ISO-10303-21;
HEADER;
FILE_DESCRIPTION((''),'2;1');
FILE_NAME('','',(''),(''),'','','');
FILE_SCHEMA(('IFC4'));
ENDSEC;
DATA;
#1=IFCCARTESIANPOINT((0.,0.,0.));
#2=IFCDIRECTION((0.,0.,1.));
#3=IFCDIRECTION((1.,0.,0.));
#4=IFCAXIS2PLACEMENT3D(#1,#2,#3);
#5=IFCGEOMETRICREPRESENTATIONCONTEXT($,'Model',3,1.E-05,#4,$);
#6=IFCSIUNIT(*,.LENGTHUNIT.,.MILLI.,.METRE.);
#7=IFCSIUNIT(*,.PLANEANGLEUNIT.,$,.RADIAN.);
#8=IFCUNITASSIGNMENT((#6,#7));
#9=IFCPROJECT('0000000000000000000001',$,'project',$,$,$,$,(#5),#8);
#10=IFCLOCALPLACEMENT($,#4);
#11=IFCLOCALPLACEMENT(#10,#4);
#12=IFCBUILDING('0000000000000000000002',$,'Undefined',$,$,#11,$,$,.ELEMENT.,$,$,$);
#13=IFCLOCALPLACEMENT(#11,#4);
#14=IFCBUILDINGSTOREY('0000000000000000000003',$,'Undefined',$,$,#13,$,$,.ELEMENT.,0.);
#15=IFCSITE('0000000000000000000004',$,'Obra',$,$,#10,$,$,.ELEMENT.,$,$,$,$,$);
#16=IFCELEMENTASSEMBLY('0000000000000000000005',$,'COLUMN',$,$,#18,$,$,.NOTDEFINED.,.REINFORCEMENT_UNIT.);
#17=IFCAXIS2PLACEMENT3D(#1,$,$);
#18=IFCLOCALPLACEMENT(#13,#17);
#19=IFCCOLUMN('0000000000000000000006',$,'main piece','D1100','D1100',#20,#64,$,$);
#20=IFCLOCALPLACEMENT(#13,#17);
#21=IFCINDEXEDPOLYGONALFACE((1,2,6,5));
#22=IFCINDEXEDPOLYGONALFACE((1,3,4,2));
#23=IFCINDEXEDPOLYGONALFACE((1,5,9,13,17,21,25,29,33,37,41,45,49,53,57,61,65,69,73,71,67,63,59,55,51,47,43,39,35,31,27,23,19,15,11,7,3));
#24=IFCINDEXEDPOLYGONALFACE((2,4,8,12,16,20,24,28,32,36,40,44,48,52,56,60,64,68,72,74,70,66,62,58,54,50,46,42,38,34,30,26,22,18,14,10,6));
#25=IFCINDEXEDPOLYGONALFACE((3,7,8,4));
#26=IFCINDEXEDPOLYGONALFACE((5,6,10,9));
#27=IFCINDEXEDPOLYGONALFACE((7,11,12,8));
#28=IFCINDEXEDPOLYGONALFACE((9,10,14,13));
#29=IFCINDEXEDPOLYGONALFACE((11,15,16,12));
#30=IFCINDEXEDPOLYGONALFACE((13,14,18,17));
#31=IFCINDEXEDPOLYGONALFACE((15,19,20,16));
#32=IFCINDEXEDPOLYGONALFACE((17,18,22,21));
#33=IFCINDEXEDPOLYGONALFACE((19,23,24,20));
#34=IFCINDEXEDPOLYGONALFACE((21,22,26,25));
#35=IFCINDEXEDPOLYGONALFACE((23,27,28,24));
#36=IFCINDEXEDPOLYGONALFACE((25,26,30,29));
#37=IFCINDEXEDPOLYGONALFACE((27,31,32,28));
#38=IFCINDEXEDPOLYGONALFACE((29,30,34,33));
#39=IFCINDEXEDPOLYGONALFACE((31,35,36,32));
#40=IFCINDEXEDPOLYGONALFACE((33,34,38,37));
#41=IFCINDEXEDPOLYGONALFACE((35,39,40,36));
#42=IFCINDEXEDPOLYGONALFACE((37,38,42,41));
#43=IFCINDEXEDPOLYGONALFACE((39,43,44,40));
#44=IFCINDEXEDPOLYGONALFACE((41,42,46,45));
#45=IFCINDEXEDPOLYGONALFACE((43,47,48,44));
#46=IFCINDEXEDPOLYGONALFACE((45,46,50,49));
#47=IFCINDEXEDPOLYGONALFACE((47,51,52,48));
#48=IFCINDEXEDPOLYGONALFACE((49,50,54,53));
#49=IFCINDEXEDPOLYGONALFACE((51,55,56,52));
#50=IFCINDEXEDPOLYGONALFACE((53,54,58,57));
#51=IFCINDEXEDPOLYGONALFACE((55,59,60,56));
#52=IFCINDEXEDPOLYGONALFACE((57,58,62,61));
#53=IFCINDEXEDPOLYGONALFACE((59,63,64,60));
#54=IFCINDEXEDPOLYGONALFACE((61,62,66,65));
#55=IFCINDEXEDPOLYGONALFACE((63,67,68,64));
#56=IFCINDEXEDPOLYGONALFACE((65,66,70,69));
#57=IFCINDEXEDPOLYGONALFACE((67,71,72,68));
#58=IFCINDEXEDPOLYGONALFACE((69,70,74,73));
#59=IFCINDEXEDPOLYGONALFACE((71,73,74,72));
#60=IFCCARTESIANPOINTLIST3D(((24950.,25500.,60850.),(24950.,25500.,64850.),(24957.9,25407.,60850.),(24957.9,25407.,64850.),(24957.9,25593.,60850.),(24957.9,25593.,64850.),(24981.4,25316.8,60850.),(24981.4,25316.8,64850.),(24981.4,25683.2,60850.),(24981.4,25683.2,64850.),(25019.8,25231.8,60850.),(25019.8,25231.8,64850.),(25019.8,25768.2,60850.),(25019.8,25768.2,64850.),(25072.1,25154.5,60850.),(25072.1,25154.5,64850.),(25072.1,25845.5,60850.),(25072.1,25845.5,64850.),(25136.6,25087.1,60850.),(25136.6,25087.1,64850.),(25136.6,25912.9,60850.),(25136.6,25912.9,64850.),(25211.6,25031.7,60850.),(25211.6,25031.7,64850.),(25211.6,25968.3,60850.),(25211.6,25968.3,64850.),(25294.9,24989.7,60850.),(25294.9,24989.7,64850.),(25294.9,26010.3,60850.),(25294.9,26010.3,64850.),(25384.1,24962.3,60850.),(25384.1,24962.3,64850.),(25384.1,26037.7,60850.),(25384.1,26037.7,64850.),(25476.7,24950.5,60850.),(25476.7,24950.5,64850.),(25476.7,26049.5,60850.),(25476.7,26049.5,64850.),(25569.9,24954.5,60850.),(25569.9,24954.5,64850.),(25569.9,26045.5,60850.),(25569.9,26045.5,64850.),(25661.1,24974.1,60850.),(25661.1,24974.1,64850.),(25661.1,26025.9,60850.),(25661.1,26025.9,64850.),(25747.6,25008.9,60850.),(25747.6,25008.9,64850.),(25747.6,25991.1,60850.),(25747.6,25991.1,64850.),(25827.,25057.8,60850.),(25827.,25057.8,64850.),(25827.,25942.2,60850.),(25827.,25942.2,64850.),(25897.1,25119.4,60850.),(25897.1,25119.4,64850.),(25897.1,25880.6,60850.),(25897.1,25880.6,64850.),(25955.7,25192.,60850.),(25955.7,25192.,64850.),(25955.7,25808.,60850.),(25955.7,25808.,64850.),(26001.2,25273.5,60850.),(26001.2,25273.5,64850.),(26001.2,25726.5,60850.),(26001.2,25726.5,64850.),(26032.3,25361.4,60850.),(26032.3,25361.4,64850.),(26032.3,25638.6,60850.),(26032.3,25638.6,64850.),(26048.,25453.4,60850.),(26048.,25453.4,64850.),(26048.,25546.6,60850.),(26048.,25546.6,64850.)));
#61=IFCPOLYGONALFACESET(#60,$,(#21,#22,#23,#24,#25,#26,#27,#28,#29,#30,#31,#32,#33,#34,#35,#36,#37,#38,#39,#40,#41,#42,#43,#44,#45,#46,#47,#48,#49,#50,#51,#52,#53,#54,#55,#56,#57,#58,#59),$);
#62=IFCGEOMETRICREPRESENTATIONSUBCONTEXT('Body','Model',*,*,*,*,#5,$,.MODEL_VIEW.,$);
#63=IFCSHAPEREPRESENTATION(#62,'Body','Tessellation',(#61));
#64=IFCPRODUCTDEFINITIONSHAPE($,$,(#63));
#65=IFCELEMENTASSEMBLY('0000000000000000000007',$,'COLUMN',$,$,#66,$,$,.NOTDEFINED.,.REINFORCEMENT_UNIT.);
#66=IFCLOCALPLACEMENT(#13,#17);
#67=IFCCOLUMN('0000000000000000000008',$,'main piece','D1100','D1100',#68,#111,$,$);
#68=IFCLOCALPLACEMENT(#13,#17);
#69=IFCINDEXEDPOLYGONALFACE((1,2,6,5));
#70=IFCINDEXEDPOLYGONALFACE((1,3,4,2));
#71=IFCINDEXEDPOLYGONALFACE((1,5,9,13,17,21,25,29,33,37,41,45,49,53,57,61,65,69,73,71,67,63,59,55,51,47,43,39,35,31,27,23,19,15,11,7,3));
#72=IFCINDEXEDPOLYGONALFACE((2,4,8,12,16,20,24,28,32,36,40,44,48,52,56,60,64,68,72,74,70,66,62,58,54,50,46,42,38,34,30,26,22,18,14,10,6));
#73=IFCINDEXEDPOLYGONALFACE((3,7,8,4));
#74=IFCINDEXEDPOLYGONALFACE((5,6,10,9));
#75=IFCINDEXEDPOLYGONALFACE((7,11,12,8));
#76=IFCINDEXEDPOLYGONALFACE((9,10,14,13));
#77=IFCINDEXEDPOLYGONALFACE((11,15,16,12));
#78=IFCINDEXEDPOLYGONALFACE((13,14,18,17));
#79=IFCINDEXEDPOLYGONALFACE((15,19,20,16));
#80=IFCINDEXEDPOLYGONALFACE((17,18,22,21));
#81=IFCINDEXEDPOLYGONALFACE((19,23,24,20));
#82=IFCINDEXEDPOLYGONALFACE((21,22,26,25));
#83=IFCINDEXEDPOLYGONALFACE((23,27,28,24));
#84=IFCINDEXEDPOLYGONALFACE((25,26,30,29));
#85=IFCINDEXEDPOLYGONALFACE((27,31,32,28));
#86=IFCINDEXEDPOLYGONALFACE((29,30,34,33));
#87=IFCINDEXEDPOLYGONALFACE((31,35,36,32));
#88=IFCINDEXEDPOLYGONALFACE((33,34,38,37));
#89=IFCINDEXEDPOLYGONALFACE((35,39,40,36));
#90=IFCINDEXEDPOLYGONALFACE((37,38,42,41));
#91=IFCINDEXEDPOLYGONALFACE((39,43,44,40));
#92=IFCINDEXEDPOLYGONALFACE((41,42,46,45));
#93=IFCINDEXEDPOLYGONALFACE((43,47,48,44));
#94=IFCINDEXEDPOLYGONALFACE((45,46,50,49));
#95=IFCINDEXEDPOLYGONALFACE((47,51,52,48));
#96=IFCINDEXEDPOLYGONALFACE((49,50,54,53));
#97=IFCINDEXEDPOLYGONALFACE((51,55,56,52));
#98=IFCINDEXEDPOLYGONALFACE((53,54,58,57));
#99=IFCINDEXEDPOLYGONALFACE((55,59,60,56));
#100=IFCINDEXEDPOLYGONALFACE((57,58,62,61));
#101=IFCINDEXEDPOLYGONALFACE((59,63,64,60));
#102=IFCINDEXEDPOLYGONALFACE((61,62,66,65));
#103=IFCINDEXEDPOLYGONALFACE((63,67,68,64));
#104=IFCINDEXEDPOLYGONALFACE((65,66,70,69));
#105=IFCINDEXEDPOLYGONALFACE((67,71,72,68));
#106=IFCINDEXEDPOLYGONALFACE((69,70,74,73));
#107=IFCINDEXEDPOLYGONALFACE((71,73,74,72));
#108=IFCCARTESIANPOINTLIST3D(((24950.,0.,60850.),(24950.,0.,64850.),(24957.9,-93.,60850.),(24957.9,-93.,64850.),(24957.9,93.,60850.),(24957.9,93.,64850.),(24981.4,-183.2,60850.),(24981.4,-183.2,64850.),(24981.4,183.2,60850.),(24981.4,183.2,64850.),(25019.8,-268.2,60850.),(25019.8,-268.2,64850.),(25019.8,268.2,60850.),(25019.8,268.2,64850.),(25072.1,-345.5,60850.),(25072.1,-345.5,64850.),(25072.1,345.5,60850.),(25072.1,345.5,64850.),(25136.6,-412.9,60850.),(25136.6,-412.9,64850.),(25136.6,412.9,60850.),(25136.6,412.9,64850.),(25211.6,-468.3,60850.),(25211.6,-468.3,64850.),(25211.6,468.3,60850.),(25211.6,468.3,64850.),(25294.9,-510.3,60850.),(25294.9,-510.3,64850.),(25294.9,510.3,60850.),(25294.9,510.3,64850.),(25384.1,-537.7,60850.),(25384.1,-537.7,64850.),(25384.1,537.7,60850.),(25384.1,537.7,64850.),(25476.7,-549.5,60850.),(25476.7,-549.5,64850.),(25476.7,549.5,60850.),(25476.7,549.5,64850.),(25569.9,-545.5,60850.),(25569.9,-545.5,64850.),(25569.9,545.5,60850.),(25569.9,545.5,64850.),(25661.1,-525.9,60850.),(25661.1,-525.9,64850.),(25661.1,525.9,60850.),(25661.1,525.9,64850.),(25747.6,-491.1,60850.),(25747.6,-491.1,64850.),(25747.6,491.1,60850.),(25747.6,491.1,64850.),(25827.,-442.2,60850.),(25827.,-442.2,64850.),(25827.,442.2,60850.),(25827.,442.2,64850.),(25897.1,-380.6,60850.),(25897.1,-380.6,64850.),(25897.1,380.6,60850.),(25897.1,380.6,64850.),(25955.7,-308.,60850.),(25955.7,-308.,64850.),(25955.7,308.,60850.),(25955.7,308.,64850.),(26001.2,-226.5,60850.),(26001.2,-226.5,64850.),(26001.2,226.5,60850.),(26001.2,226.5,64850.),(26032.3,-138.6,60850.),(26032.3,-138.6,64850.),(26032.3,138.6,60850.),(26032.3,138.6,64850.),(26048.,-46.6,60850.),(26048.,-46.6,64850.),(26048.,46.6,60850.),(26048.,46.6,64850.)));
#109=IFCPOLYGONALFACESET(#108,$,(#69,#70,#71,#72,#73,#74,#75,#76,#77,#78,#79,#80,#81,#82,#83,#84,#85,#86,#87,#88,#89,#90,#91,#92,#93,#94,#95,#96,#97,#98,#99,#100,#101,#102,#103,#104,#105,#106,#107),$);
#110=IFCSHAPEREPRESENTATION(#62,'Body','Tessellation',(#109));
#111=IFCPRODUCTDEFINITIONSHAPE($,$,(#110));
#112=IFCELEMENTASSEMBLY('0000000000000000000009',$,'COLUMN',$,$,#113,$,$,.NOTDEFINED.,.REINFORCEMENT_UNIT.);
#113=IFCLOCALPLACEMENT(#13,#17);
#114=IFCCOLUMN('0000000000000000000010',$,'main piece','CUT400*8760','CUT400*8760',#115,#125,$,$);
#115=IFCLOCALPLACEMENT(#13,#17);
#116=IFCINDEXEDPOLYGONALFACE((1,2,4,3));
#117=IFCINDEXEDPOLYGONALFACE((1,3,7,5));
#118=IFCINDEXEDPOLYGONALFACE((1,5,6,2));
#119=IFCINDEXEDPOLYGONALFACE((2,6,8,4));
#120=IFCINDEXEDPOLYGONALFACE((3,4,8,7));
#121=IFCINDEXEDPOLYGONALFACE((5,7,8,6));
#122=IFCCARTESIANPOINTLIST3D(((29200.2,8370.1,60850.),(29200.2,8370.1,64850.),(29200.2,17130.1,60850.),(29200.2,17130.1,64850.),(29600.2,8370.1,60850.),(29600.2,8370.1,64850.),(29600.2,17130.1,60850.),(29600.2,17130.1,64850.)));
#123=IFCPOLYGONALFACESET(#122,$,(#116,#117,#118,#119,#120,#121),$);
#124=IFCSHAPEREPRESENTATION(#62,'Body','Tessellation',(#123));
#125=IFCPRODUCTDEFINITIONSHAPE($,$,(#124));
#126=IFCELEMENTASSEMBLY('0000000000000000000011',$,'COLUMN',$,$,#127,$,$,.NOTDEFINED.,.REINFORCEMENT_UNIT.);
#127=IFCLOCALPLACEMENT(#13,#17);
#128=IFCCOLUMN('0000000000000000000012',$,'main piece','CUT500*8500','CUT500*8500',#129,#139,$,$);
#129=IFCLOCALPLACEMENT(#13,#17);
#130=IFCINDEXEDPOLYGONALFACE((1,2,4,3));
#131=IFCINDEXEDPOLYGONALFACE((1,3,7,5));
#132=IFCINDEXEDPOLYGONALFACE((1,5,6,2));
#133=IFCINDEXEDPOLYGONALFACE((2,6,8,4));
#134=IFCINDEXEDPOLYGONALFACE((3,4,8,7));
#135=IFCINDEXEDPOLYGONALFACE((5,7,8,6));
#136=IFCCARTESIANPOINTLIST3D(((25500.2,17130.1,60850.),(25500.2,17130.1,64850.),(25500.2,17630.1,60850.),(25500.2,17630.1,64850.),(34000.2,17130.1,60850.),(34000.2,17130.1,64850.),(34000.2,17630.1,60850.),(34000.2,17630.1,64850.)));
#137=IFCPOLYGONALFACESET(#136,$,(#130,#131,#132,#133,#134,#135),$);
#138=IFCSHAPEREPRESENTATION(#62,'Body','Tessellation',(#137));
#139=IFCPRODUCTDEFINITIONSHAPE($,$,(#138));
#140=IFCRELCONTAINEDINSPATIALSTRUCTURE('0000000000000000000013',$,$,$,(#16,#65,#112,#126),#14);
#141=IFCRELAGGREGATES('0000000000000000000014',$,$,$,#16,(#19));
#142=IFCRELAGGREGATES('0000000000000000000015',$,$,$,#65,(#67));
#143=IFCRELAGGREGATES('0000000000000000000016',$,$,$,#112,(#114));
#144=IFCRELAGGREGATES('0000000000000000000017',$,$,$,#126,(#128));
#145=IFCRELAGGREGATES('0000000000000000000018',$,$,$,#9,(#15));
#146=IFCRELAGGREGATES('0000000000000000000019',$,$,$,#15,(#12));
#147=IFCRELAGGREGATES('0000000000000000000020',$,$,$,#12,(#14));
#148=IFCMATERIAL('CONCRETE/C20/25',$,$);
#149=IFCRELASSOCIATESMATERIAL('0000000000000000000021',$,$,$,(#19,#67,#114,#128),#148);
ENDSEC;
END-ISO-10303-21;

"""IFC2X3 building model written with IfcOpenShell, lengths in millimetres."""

from ifc_helpers import new_model, si_unit, frame, origin_with_axes, origin_2d_with_axis, place, context, subcontext, project, spatial, rectangle, circle, extrude, material, element, aggregate, save


model = new_model("IFC2X3")

# Units and contexts
model_context = context("Model", 3, precision=1e-05, world=origin_with_axes())
body_context = subcontext(model_context, "Body", "Model", "MODEL_VIEW")
ifc_project = project(units=[si_unit("LENGTHUNIT", "METRE", prefix="MILLI"), si_unit("PLANEANGLEUNIT", "RADIAN")], contexts=[model_context])

# Site, building, storey
site_placement = place(None, origin_with_axes())
site = spatial("IfcSite", under=ifc_project, at=site_placement, Name="Obra", CompositionType="ELEMENT")
building_placement = place(site_placement, origin_with_axes())
building = spatial("IfcBuilding", under=site, at=building_placement, Name="Undefined", CompositionType="ELEMENT")
storey_placement = place(building_placement, origin_with_axes())
storey = spatial("IfcBuildingStorey", under=building, at=storey_placement, Name="Undefined", CompositionType="ELEMENT", Elevation=0.0)

# Element assemblies, columns
assembly_1_placement = place(storey_placement, origin_with_axes())
assembly_1 = element("IfcElementAssembly", 1, at=assembly_1_placement, inside=storey, Name="COLUMN", AssemblyPlace="NOTDEFINED", PredefinedType="REINFORCEMENT_UNIT")
ifc_material_1 = material(Name="CONCRETE/C20/25")
column_1_placement = place(assembly_1_placement, frame((25500.0, 25500.0, 60850.0), z_axis=(0.0, 0.0, 1.0), x_axis=(0.0, 1.0, 0.0)))
column_1 = element("IfcColumn", 2, at=column_1_placement, material=ifc_material_1, Name="main piece", Description="D1100", ObjectType="D1100", context=body_context, shape_type="SweptSolid", body=[
    extrude(circle(Radius=550.0, at=origin_2d_with_axis()), frame((0.0, 0.0, 4000.0), z_axis=(0.0, 0.0, -1.0), x_axis=(0.0, 1.0, 0.0)), (0.0, 0.0, 1.0), 4000.0),
])
aggregate(assembly_1, [column_1])
assembly_2_placement = place(storey_placement, origin_with_axes())
assembly_2 = element("IfcElementAssembly", 3, at=assembly_2_placement, inside=storey, Name="COLUMN", AssemblyPlace="NOTDEFINED", PredefinedType="REINFORCEMENT_UNIT")
column_2_placement = place(assembly_2_placement, frame((25500.0, 0.0, 60850.0), z_axis=(0.0, 0.0, 1.0), x_axis=(0.0, 1.0, 0.0)))
column_2 = element("IfcColumn", 4, at=column_2_placement, material=ifc_material_1, Name="main piece", Description="D1100", ObjectType="D1100", context=body_context, shape_type="SweptSolid", body=[
    extrude(circle(Radius=550.0, at=origin_2d_with_axis()), frame((0.0, 0.0, 4000.0), z_axis=(0.0, 0.0, -1.0), x_axis=(0.0, 1.0, 0.0)), (0.0, 0.0, 1.0), 4000.0),
])
aggregate(assembly_2, [column_2])
assembly_3_placement = place(storey_placement, origin_with_axes())
assembly_3 = element("IfcElementAssembly", 5, at=assembly_3_placement, inside=storey, Name="COLUMN", AssemblyPlace="NOTDEFINED", PredefinedType="REINFORCEMENT_UNIT")
column_3_placement = place(assembly_3_placement, frame((29400.2, 12750.1, 60850.0), z_axis=(0.0, 0.0, 1.0), x_axis=(0.0, -1.0, 0.0)))
column_3 = element("IfcColumn", 6, at=column_3_placement, material=ifc_material_1, Name="main piece", Description="CUT400*8760", ObjectType="CUT400*8760", context=body_context, shape_type="SweptSolid", body=[
    extrude(rectangle(XDim=400.0, YDim=8760.0, at=origin_2d_with_axis()), frame((0.0, 0.0, 4000.0), z_axis=(0.0, 0.0, -1.0), x_axis=(0.0, 1.0, 0.0)), (0.0, 0.0, 1.0), 4000.0),
])
aggregate(assembly_3, [column_3])
assembly_4_placement = place(storey_placement, origin_with_axes())
assembly_4 = element("IfcElementAssembly", 7, at=assembly_4_placement, inside=storey, Name="COLUMN", AssemblyPlace="NOTDEFINED", PredefinedType="REINFORCEMENT_UNIT")
column_4_placement = place(assembly_4_placement, frame((29750.2, 17380.1, 60850.0), z_axis=(0.0, 0.0, 1.0), x_axis=(-1.0, 0.0, 0.0)))
column_4 = element("IfcColumn", 8, at=column_4_placement, material=ifc_material_1, Name="main piece", Description="CUT500*8500", ObjectType="CUT500*8500", context=body_context, shape_type="SweptSolid", body=[
    extrude(rectangle(XDim=500.0, YDim=8500.0, at=origin_2d_with_axis()), frame((0.0, 0.0, 4000.0), z_axis=(0.0, 0.0, -1.0), x_axis=(0.0, 1.0, 0.0)), (0.0, 0.0, 1.0), 4000.0),
])
aggregate(assembly_4, [column_4])

save(model, "model.ifc")
